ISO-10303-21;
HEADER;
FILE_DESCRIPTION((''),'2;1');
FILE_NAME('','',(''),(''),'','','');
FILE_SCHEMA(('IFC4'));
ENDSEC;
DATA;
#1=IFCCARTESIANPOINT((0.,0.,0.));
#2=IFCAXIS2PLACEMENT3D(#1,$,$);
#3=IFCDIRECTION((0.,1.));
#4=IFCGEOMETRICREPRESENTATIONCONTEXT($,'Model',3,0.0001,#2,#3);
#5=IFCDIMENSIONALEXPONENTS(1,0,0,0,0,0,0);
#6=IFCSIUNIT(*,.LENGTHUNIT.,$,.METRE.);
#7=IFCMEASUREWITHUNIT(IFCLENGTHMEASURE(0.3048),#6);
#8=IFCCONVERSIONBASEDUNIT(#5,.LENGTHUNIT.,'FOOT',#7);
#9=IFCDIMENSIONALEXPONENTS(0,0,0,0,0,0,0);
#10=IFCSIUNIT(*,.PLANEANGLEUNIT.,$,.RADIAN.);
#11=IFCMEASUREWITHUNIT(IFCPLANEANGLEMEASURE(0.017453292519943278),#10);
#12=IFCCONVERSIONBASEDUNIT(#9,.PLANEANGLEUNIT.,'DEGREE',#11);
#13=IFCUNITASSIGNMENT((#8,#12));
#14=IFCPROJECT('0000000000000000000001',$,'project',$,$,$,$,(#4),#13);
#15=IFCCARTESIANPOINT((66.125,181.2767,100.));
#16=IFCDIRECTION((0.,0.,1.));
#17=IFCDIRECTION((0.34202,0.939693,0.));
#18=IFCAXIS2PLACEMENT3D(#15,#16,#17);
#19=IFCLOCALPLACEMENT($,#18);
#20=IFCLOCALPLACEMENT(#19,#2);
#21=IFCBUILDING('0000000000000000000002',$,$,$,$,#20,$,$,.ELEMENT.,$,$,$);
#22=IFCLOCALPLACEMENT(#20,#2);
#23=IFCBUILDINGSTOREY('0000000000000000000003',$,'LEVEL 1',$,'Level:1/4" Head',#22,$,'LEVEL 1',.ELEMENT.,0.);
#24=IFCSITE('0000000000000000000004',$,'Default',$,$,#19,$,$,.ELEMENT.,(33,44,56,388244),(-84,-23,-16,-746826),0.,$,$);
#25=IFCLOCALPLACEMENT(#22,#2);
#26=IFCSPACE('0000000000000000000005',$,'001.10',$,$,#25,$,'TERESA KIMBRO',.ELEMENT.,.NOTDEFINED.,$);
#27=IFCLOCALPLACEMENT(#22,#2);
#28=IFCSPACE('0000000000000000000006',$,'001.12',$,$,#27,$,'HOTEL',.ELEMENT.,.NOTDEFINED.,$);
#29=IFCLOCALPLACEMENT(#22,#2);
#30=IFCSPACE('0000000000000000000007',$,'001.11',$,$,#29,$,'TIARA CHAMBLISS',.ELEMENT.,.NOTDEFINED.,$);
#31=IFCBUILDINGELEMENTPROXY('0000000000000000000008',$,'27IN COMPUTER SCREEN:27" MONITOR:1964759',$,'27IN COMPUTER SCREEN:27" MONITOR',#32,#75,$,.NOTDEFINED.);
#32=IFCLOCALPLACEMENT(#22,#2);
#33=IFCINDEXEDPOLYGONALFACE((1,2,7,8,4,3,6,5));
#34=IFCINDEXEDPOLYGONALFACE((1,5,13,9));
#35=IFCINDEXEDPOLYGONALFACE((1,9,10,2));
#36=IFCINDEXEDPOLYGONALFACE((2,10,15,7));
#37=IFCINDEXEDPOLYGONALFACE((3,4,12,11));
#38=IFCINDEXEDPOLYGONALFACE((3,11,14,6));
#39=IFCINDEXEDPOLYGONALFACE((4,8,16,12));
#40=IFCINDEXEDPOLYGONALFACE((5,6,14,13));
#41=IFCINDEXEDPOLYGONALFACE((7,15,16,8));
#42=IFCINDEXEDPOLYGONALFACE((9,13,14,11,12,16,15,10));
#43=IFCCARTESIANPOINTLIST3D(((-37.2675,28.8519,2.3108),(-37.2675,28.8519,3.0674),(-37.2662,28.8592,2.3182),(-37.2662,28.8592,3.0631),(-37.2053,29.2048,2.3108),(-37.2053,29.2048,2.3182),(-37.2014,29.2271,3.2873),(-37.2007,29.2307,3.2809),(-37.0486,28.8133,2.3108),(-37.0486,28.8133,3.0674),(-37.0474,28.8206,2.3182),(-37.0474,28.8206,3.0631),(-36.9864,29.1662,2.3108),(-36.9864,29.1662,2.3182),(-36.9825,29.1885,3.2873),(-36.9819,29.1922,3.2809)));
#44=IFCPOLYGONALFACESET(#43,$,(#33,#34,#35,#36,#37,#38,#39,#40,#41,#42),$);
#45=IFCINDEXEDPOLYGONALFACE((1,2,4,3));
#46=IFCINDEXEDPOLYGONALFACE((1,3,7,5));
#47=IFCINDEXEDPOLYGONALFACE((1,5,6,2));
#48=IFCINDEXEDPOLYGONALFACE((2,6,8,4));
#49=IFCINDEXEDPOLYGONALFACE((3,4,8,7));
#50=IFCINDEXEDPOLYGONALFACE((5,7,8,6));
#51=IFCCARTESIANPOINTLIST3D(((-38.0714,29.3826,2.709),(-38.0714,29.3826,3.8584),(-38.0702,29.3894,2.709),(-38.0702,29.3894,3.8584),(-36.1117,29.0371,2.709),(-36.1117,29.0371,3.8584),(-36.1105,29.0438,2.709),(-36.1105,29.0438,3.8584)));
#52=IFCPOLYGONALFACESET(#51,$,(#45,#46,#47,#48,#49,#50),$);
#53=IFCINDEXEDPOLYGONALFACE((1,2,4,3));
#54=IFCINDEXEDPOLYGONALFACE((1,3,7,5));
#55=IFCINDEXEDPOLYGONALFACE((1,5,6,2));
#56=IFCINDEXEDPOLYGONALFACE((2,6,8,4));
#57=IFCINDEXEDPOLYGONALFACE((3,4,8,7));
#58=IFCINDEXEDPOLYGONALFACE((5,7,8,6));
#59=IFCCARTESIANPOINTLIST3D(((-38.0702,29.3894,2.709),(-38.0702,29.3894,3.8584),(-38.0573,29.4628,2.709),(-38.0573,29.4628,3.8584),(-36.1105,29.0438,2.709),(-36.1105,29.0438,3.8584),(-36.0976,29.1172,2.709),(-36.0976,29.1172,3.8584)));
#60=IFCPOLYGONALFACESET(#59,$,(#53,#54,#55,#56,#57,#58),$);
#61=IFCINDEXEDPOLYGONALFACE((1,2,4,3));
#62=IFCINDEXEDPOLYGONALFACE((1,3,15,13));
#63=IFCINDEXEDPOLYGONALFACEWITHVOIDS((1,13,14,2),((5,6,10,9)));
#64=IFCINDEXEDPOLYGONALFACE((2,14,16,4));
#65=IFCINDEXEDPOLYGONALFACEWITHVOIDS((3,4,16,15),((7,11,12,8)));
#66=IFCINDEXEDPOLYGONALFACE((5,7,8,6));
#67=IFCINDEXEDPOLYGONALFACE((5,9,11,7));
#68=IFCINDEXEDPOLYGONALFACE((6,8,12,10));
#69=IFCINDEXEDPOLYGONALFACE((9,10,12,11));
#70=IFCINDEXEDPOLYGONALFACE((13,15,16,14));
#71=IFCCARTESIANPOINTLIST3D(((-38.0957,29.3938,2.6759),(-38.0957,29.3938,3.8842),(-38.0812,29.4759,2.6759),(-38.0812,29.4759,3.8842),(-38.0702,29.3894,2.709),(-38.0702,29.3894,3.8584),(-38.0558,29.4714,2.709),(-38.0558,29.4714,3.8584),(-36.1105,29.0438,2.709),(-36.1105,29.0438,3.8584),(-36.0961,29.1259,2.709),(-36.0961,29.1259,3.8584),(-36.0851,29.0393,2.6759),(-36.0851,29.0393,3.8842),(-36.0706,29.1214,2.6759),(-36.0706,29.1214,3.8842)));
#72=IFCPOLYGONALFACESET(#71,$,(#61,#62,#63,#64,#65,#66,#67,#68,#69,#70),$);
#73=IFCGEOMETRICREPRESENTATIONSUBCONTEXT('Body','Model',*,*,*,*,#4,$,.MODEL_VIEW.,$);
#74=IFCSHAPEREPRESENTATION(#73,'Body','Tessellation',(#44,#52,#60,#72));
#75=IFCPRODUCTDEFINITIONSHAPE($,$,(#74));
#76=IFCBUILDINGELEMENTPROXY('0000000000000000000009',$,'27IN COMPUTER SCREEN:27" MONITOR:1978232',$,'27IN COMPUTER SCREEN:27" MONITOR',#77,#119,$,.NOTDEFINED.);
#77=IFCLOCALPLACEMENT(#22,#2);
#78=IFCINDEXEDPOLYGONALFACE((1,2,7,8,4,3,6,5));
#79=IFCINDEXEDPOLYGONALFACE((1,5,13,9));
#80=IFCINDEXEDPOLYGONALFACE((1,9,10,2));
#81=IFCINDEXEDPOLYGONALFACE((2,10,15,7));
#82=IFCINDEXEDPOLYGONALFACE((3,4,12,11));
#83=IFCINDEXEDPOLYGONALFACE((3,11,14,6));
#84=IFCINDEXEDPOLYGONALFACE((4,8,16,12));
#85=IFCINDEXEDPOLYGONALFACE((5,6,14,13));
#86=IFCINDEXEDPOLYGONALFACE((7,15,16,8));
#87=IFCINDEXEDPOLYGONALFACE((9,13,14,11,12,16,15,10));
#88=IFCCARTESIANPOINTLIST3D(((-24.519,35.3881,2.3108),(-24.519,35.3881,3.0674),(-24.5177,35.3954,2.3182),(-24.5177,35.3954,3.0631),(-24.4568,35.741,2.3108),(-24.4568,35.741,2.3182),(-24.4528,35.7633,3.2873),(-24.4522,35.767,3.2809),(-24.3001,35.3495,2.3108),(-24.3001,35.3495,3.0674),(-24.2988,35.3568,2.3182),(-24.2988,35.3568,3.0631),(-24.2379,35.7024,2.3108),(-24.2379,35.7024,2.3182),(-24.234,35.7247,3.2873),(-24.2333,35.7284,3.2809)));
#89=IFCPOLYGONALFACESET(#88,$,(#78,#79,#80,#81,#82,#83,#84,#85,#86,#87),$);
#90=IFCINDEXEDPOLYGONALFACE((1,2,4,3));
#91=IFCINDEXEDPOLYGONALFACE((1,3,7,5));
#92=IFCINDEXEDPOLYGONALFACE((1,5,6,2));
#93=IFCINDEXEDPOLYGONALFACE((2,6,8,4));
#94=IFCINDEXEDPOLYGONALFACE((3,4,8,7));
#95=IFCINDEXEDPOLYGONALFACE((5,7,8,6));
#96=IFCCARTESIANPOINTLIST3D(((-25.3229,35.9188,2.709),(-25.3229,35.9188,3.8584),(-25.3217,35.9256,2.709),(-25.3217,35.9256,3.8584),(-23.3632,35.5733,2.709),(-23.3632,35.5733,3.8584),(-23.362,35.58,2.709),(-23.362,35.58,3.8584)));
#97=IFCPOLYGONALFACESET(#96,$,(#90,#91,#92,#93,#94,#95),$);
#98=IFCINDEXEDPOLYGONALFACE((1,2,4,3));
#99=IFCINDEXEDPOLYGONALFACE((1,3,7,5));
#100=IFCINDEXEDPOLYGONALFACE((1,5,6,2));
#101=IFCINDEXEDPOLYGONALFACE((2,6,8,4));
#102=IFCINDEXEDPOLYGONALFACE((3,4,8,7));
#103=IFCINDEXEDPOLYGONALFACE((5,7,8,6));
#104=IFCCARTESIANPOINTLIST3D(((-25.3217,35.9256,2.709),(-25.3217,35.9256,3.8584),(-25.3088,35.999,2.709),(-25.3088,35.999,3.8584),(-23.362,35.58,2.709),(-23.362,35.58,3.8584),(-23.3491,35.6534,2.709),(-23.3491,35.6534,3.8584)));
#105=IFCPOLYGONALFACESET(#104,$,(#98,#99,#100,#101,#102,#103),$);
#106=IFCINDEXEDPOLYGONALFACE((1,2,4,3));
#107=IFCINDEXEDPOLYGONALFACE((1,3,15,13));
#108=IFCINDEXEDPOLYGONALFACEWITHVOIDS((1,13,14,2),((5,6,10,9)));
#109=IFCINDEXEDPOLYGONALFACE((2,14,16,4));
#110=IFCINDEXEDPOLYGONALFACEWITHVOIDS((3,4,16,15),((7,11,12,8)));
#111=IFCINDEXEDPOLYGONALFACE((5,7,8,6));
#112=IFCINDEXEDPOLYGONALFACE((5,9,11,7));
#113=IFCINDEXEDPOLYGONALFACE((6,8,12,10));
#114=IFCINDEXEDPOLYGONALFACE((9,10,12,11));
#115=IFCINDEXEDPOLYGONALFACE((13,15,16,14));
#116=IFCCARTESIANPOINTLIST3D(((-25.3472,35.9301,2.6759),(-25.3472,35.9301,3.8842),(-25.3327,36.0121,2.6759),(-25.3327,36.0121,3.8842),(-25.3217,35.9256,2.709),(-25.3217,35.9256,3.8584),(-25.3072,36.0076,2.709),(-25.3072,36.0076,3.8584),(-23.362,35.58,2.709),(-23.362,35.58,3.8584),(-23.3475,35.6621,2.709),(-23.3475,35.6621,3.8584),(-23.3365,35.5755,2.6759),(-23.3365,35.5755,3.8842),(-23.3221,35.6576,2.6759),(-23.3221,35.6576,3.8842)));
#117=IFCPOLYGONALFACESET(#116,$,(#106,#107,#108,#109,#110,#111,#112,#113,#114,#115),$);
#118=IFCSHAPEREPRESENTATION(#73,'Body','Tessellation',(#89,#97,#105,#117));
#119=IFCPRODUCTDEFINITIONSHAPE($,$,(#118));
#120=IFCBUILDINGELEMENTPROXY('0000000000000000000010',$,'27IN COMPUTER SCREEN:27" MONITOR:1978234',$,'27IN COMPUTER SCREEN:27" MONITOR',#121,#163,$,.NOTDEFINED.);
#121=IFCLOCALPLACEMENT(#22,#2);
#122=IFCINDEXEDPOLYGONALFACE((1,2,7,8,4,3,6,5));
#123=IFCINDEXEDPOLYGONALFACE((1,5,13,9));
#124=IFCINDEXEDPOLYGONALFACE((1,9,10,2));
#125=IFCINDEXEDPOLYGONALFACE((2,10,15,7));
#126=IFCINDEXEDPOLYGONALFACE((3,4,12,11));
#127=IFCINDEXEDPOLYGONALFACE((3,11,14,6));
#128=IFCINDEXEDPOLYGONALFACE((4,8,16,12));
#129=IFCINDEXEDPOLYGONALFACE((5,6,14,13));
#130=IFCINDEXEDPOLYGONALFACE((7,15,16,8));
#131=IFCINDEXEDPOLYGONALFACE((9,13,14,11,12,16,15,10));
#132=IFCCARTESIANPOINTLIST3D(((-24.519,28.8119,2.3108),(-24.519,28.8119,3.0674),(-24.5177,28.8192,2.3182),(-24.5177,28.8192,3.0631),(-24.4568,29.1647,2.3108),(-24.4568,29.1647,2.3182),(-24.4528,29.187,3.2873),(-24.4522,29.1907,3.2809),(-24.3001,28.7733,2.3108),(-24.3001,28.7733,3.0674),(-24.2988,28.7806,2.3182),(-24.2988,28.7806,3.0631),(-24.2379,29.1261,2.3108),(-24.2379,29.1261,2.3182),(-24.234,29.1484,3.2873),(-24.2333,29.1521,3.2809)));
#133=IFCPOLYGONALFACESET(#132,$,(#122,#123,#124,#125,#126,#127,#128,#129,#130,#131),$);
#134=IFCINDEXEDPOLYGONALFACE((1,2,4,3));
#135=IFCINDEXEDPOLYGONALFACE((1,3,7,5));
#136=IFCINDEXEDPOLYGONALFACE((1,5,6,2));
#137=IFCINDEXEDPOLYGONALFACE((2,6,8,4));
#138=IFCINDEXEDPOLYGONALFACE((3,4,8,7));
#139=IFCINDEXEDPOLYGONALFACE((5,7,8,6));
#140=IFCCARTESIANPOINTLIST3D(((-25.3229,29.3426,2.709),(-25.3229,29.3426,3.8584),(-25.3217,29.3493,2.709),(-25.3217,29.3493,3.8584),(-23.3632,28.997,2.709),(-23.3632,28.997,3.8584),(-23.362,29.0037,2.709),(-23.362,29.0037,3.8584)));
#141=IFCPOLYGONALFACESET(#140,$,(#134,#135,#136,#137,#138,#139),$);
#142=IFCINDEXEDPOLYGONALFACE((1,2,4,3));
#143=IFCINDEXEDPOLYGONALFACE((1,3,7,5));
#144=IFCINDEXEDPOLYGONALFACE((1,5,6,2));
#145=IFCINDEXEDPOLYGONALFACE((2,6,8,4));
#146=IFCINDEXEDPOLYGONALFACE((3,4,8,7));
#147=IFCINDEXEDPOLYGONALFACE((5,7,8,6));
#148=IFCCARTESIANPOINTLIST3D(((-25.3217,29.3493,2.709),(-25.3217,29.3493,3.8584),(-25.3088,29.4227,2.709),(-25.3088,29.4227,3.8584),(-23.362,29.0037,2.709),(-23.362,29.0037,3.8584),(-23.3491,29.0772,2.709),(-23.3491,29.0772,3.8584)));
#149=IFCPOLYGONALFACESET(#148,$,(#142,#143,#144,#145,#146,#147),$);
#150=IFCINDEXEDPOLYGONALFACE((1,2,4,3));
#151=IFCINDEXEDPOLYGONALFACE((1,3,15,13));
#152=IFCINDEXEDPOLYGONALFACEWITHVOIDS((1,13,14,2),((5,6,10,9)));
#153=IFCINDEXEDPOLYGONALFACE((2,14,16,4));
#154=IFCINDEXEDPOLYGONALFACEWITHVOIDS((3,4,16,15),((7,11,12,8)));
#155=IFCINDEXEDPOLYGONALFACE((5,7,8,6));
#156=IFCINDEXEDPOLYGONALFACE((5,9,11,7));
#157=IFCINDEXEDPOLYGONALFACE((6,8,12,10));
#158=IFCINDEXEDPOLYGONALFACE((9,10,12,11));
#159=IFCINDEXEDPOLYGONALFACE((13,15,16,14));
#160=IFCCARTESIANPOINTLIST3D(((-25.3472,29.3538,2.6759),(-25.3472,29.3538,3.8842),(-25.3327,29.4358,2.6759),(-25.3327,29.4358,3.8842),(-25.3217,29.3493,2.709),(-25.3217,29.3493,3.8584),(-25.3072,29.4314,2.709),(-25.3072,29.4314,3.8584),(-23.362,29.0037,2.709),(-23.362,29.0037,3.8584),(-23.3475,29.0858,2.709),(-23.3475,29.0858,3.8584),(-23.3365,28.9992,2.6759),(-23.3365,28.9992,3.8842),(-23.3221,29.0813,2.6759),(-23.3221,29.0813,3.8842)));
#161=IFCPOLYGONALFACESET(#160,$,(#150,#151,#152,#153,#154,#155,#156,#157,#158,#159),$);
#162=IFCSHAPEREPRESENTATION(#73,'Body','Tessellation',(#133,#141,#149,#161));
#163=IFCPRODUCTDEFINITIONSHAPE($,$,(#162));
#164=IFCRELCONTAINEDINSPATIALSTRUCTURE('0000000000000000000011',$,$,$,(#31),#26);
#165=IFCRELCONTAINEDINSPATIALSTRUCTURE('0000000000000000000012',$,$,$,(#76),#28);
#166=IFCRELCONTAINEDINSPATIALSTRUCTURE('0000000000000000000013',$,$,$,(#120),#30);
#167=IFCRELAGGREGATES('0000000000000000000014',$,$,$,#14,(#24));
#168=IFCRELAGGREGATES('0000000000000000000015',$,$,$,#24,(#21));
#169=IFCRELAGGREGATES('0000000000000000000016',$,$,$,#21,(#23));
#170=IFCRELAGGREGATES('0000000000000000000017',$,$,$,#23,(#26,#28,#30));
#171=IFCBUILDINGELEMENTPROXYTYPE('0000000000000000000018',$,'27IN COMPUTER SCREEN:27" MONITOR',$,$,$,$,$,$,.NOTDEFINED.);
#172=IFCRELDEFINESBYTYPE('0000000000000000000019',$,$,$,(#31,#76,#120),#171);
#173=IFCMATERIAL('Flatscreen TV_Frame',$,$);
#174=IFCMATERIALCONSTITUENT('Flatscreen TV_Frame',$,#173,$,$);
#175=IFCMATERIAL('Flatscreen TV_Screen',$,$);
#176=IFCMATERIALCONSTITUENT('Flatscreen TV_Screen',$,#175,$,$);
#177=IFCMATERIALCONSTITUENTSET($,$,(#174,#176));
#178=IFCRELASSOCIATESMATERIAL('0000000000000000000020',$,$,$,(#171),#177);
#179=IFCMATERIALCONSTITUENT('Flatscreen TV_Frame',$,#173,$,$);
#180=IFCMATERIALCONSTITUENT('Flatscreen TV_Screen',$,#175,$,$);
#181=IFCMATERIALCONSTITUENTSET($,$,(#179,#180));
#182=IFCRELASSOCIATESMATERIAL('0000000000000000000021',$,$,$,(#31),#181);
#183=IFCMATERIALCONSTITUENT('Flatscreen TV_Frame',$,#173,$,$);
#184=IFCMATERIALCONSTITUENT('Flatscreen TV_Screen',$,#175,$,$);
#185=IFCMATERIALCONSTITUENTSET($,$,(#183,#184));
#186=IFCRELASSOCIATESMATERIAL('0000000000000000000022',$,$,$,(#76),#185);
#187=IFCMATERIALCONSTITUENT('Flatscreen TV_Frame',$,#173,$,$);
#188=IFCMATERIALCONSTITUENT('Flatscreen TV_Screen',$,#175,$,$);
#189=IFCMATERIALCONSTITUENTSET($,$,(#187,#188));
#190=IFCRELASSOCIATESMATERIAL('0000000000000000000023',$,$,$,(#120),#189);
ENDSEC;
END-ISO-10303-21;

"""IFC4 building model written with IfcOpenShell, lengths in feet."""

from ifc_helpers import new_model, entity, si_unit, converted_unit, direction, frame, frame_2d, origin, origin_2d_with_axis, place, context, subcontext, project, spatial, polyline, rectangle, outline, extrude, source, transform, mapped, material, constituent, constituent_set, type_object, type_shapes, element, save


model = new_model("IFC4")

# Units and contexts
model_context = context("Model", 3, precision=0.0001, world=origin(), true_north=direction((0.0, 1.0)))
body_context = subcontext(model_context, "Body", "Model", "MODEL_VIEW")
ifc_project = project(units=[converted_unit("LENGTHUNIT", "FOOT", entity("IfcLengthMeasure", 0.3048), si_unit("LENGTHUNIT", "METRE"), dimensions=[1, 0, 0, 0, 0, 0, 0]), converted_unit("PLANEANGLEUNIT", "DEGREE", entity("IfcPlaneAngleMeasure", 0.017453292519943278), si_unit("PLANEANGLEUNIT", "RADIAN"), dimensions=[0, 0, 0, 0, 0, 0, 0])], contexts=[model_context])

# Site, building, storey
site_placement = place(None, frame((66.125, 181.2767, 100.0), z_axis=(0.0, 0.0, 1.0), x_axis=(0.34202, 0.939693, 0.0)))
site = spatial("IfcSite", under=ifc_project, at=site_placement, Name="Default", CompositionType="ELEMENT", RefLatitude=(33, 44, 56, 388244), RefLongitude=(-84, -23, -16, -746826), RefElevation=0.0)
building_placement = place(site_placement, origin())
building = spatial("IfcBuilding", under=site, at=building_placement, CompositionType="ELEMENT")
storey_placement = place(building_placement, origin())
storey = spatial("IfcBuildingStorey", under=building, at=storey_placement, Name="LEVEL 1", ObjectType="Level:1/4\" Head", LongName="LEVEL 1", CompositionType="ELEMENT", Elevation=0.0)

# Shared definitions
space_1_placement = place(storey_placement, origin())
space_1 = spatial("IfcSpace", under=storey, at=space_1_placement, Name="001.10", LongName="TERESA KIMBRO", CompositionType="ELEMENT", PredefinedType="NOTDEFINED")

# Building element proxy
ifc_material_1 = material(Name="Flatscreen TV_Frame")
ifc_constituent_1 = constituent(ifc_material_1, Name="Flatscreen TV_Frame")
ifc_material_2 = material(Name="Flatscreen TV_Screen")
ifc_constituent_2 = constituent(ifc_material_2, Name="Flatscreen TV_Screen")
ifc_constituent_set_1 = constituent_set(constituents=[ifc_constituent_1, ifc_constituent_2])
ifc_constituent_3 = constituent(ifc_material_1, Name="Flatscreen TV_Frame")
ifc_constituent_4 = constituent(ifc_material_2, Name="Flatscreen TV_Screen")
ifc_constituent_set_2 = constituent_set(constituents=[ifc_constituent_3, ifc_constituent_4])
building_element_proxy_type_1 = type_object("IfcBuildingElementProxyType", Name="27IN COMPUTER SCREEN:27\" MONITOR", PredefinedType="NOTDEFINED", material=ifc_constituent_set_2)
shared_shape_1 = source(origin(), body_context, "Body", "SweptSolid", [
    extrude(outline(polyline([(-0.4392, -0.3657), (-0.4392, -0.3731), (0.0007, -0.3731), (0.379, 0.2821), (0.0686, 0.4613), (0.0649, 0.4548), (0.3688, 0.2794), (-0.0036, -0.3657), (-0.4392, -0.3657)])), frame((-0.1111, -0.0264, 0.0687), z_axis=(-1.0, 0.0, 0.0), x_axis=(0.0, 0.866025, -0.5)), (0.0, 0.0, -1.0), 0.2222),
    extrude(rectangle(XDim=0.0068, YDim=1.9899, at=origin_2d_with_axis()), frame((0.0, -0.2257, 0.0331), z_axis=(0.0, 0.0, 1.0), x_axis=(0.0, 1.0, 0.0)), (0.0, 0.0, 1.0), 1.1493),
    extrude(rectangle(XDim=0.0746, YDim=1.9899, at=frame_2d((0.0, 0.0), x_axis=(1.0, 0.0))), frame((0.0, -0.2664, 0.0331), z_axis=(0.0, 0.0, 1.0), x_axis=(0.0, 1.0, 0.0)), (0.0, 0.0, 1.0), 1.1493),
    extrude(outline(polyline([(-0.6042, -1.0208), (0.6042, -1.0208), (0.6042, 1.0208), (-0.6042, 1.0208), (-0.6042, -1.0208)]), holes=[polyline([(-0.5783, -0.995), (-0.5783, 0.995), (0.571, 0.995), (0.571, -0.995), (-0.5783, -0.995)])]), frame((0.0, -0.3125, 0.6042), z_axis=(0.0, 1.0, 0.0), x_axis=(0.0, 0.0, -1.0)), (0.0, 0.0, 1.0), 0.0833),
])
type_shapes(building_element_proxy_type_1, [shared_shape_1])
proxy_1_placement = place(space_1_placement, frame((-37.1302, 28.9909, 2.6759), z_axis=(0.0, 0.0, 1.0), x_axis=(-0.984808, 0.173648, 0.0)))
element("IfcBuildingElementProxy", 1, at=proxy_1_placement, inside=space_1, type_object=building_element_proxy_type_1, material=ifc_constituent_set_1, Name="27IN COMPUTER SCREEN:27\" MONITOR:1964759", ObjectType="27IN COMPUTER SCREEN:27\" MONITOR", PredefinedType="NOTDEFINED", context=body_context, shape_type="MappedRepresentation", body=[
    mapped(shared_shape_1, transform((0.0, 0.0, 0.0), scale=1.0)),
])

# Shared definitions
space_2_placement = place(storey_placement, origin())
space_2 = spatial("IfcSpace", under=storey, at=space_2_placement, Name="001.12", LongName="HOTEL", CompositionType="ELEMENT", PredefinedType="NOTDEFINED")

# Building element proxy
ifc_constituent_5 = constituent(ifc_material_1, Name="Flatscreen TV_Frame")
ifc_constituent_6 = constituent(ifc_material_2, Name="Flatscreen TV_Screen")
ifc_constituent_set_3 = constituent_set(constituents=[ifc_constituent_5, ifc_constituent_6])
proxy_2_placement = place(space_2_placement, frame((-24.3817, 35.5271, 2.6759), z_axis=(0.0, 0.0, 1.0), x_axis=(-0.984808, 0.173648, 0.0)))
element("IfcBuildingElementProxy", 2, at=proxy_2_placement, inside=space_2, type_object=building_element_proxy_type_1, material=ifc_constituent_set_3, Name="27IN COMPUTER SCREEN:27\" MONITOR:1978232", ObjectType="27IN COMPUTER SCREEN:27\" MONITOR", PredefinedType="NOTDEFINED", context=body_context, shape_type="MappedRepresentation", body=[
    mapped(shared_shape_1, transform((0.0, 0.0, 0.0), scale=1.0)),
])

# Shared definitions
space_3_placement = place(storey_placement, origin())
space_3 = spatial("IfcSpace", under=storey, at=space_3_placement, Name="001.11", LongName="TIARA CHAMBLISS", CompositionType="ELEMENT", PredefinedType="NOTDEFINED")

# Building element proxy
ifc_constituent_7 = constituent(ifc_material_1, Name="Flatscreen TV_Frame")
ifc_constituent_8 = constituent(ifc_material_2, Name="Flatscreen TV_Screen")
ifc_constituent_set_4 = constituent_set(constituents=[ifc_constituent_7, ifc_constituent_8])
proxy_3_placement = place(space_3_placement, frame((-24.3817, 28.9508, 2.6759), z_axis=(0.0, 0.0, 1.0), x_axis=(-0.984808, 0.173648, 0.0)))
element("IfcBuildingElementProxy", 3, at=proxy_3_placement, inside=space_3, type_object=building_element_proxy_type_1, material=ifc_constituent_set_4, Name="27IN COMPUTER SCREEN:27\" MONITOR:1978234", ObjectType="27IN COMPUTER SCREEN:27\" MONITOR", PredefinedType="NOTDEFINED", context=body_context, shape_type="MappedRepresentation", body=[
    mapped(shared_shape_1, transform((0.0, 0.0, 0.0), scale=1.0)),
])

save(model, "model.ifc")
